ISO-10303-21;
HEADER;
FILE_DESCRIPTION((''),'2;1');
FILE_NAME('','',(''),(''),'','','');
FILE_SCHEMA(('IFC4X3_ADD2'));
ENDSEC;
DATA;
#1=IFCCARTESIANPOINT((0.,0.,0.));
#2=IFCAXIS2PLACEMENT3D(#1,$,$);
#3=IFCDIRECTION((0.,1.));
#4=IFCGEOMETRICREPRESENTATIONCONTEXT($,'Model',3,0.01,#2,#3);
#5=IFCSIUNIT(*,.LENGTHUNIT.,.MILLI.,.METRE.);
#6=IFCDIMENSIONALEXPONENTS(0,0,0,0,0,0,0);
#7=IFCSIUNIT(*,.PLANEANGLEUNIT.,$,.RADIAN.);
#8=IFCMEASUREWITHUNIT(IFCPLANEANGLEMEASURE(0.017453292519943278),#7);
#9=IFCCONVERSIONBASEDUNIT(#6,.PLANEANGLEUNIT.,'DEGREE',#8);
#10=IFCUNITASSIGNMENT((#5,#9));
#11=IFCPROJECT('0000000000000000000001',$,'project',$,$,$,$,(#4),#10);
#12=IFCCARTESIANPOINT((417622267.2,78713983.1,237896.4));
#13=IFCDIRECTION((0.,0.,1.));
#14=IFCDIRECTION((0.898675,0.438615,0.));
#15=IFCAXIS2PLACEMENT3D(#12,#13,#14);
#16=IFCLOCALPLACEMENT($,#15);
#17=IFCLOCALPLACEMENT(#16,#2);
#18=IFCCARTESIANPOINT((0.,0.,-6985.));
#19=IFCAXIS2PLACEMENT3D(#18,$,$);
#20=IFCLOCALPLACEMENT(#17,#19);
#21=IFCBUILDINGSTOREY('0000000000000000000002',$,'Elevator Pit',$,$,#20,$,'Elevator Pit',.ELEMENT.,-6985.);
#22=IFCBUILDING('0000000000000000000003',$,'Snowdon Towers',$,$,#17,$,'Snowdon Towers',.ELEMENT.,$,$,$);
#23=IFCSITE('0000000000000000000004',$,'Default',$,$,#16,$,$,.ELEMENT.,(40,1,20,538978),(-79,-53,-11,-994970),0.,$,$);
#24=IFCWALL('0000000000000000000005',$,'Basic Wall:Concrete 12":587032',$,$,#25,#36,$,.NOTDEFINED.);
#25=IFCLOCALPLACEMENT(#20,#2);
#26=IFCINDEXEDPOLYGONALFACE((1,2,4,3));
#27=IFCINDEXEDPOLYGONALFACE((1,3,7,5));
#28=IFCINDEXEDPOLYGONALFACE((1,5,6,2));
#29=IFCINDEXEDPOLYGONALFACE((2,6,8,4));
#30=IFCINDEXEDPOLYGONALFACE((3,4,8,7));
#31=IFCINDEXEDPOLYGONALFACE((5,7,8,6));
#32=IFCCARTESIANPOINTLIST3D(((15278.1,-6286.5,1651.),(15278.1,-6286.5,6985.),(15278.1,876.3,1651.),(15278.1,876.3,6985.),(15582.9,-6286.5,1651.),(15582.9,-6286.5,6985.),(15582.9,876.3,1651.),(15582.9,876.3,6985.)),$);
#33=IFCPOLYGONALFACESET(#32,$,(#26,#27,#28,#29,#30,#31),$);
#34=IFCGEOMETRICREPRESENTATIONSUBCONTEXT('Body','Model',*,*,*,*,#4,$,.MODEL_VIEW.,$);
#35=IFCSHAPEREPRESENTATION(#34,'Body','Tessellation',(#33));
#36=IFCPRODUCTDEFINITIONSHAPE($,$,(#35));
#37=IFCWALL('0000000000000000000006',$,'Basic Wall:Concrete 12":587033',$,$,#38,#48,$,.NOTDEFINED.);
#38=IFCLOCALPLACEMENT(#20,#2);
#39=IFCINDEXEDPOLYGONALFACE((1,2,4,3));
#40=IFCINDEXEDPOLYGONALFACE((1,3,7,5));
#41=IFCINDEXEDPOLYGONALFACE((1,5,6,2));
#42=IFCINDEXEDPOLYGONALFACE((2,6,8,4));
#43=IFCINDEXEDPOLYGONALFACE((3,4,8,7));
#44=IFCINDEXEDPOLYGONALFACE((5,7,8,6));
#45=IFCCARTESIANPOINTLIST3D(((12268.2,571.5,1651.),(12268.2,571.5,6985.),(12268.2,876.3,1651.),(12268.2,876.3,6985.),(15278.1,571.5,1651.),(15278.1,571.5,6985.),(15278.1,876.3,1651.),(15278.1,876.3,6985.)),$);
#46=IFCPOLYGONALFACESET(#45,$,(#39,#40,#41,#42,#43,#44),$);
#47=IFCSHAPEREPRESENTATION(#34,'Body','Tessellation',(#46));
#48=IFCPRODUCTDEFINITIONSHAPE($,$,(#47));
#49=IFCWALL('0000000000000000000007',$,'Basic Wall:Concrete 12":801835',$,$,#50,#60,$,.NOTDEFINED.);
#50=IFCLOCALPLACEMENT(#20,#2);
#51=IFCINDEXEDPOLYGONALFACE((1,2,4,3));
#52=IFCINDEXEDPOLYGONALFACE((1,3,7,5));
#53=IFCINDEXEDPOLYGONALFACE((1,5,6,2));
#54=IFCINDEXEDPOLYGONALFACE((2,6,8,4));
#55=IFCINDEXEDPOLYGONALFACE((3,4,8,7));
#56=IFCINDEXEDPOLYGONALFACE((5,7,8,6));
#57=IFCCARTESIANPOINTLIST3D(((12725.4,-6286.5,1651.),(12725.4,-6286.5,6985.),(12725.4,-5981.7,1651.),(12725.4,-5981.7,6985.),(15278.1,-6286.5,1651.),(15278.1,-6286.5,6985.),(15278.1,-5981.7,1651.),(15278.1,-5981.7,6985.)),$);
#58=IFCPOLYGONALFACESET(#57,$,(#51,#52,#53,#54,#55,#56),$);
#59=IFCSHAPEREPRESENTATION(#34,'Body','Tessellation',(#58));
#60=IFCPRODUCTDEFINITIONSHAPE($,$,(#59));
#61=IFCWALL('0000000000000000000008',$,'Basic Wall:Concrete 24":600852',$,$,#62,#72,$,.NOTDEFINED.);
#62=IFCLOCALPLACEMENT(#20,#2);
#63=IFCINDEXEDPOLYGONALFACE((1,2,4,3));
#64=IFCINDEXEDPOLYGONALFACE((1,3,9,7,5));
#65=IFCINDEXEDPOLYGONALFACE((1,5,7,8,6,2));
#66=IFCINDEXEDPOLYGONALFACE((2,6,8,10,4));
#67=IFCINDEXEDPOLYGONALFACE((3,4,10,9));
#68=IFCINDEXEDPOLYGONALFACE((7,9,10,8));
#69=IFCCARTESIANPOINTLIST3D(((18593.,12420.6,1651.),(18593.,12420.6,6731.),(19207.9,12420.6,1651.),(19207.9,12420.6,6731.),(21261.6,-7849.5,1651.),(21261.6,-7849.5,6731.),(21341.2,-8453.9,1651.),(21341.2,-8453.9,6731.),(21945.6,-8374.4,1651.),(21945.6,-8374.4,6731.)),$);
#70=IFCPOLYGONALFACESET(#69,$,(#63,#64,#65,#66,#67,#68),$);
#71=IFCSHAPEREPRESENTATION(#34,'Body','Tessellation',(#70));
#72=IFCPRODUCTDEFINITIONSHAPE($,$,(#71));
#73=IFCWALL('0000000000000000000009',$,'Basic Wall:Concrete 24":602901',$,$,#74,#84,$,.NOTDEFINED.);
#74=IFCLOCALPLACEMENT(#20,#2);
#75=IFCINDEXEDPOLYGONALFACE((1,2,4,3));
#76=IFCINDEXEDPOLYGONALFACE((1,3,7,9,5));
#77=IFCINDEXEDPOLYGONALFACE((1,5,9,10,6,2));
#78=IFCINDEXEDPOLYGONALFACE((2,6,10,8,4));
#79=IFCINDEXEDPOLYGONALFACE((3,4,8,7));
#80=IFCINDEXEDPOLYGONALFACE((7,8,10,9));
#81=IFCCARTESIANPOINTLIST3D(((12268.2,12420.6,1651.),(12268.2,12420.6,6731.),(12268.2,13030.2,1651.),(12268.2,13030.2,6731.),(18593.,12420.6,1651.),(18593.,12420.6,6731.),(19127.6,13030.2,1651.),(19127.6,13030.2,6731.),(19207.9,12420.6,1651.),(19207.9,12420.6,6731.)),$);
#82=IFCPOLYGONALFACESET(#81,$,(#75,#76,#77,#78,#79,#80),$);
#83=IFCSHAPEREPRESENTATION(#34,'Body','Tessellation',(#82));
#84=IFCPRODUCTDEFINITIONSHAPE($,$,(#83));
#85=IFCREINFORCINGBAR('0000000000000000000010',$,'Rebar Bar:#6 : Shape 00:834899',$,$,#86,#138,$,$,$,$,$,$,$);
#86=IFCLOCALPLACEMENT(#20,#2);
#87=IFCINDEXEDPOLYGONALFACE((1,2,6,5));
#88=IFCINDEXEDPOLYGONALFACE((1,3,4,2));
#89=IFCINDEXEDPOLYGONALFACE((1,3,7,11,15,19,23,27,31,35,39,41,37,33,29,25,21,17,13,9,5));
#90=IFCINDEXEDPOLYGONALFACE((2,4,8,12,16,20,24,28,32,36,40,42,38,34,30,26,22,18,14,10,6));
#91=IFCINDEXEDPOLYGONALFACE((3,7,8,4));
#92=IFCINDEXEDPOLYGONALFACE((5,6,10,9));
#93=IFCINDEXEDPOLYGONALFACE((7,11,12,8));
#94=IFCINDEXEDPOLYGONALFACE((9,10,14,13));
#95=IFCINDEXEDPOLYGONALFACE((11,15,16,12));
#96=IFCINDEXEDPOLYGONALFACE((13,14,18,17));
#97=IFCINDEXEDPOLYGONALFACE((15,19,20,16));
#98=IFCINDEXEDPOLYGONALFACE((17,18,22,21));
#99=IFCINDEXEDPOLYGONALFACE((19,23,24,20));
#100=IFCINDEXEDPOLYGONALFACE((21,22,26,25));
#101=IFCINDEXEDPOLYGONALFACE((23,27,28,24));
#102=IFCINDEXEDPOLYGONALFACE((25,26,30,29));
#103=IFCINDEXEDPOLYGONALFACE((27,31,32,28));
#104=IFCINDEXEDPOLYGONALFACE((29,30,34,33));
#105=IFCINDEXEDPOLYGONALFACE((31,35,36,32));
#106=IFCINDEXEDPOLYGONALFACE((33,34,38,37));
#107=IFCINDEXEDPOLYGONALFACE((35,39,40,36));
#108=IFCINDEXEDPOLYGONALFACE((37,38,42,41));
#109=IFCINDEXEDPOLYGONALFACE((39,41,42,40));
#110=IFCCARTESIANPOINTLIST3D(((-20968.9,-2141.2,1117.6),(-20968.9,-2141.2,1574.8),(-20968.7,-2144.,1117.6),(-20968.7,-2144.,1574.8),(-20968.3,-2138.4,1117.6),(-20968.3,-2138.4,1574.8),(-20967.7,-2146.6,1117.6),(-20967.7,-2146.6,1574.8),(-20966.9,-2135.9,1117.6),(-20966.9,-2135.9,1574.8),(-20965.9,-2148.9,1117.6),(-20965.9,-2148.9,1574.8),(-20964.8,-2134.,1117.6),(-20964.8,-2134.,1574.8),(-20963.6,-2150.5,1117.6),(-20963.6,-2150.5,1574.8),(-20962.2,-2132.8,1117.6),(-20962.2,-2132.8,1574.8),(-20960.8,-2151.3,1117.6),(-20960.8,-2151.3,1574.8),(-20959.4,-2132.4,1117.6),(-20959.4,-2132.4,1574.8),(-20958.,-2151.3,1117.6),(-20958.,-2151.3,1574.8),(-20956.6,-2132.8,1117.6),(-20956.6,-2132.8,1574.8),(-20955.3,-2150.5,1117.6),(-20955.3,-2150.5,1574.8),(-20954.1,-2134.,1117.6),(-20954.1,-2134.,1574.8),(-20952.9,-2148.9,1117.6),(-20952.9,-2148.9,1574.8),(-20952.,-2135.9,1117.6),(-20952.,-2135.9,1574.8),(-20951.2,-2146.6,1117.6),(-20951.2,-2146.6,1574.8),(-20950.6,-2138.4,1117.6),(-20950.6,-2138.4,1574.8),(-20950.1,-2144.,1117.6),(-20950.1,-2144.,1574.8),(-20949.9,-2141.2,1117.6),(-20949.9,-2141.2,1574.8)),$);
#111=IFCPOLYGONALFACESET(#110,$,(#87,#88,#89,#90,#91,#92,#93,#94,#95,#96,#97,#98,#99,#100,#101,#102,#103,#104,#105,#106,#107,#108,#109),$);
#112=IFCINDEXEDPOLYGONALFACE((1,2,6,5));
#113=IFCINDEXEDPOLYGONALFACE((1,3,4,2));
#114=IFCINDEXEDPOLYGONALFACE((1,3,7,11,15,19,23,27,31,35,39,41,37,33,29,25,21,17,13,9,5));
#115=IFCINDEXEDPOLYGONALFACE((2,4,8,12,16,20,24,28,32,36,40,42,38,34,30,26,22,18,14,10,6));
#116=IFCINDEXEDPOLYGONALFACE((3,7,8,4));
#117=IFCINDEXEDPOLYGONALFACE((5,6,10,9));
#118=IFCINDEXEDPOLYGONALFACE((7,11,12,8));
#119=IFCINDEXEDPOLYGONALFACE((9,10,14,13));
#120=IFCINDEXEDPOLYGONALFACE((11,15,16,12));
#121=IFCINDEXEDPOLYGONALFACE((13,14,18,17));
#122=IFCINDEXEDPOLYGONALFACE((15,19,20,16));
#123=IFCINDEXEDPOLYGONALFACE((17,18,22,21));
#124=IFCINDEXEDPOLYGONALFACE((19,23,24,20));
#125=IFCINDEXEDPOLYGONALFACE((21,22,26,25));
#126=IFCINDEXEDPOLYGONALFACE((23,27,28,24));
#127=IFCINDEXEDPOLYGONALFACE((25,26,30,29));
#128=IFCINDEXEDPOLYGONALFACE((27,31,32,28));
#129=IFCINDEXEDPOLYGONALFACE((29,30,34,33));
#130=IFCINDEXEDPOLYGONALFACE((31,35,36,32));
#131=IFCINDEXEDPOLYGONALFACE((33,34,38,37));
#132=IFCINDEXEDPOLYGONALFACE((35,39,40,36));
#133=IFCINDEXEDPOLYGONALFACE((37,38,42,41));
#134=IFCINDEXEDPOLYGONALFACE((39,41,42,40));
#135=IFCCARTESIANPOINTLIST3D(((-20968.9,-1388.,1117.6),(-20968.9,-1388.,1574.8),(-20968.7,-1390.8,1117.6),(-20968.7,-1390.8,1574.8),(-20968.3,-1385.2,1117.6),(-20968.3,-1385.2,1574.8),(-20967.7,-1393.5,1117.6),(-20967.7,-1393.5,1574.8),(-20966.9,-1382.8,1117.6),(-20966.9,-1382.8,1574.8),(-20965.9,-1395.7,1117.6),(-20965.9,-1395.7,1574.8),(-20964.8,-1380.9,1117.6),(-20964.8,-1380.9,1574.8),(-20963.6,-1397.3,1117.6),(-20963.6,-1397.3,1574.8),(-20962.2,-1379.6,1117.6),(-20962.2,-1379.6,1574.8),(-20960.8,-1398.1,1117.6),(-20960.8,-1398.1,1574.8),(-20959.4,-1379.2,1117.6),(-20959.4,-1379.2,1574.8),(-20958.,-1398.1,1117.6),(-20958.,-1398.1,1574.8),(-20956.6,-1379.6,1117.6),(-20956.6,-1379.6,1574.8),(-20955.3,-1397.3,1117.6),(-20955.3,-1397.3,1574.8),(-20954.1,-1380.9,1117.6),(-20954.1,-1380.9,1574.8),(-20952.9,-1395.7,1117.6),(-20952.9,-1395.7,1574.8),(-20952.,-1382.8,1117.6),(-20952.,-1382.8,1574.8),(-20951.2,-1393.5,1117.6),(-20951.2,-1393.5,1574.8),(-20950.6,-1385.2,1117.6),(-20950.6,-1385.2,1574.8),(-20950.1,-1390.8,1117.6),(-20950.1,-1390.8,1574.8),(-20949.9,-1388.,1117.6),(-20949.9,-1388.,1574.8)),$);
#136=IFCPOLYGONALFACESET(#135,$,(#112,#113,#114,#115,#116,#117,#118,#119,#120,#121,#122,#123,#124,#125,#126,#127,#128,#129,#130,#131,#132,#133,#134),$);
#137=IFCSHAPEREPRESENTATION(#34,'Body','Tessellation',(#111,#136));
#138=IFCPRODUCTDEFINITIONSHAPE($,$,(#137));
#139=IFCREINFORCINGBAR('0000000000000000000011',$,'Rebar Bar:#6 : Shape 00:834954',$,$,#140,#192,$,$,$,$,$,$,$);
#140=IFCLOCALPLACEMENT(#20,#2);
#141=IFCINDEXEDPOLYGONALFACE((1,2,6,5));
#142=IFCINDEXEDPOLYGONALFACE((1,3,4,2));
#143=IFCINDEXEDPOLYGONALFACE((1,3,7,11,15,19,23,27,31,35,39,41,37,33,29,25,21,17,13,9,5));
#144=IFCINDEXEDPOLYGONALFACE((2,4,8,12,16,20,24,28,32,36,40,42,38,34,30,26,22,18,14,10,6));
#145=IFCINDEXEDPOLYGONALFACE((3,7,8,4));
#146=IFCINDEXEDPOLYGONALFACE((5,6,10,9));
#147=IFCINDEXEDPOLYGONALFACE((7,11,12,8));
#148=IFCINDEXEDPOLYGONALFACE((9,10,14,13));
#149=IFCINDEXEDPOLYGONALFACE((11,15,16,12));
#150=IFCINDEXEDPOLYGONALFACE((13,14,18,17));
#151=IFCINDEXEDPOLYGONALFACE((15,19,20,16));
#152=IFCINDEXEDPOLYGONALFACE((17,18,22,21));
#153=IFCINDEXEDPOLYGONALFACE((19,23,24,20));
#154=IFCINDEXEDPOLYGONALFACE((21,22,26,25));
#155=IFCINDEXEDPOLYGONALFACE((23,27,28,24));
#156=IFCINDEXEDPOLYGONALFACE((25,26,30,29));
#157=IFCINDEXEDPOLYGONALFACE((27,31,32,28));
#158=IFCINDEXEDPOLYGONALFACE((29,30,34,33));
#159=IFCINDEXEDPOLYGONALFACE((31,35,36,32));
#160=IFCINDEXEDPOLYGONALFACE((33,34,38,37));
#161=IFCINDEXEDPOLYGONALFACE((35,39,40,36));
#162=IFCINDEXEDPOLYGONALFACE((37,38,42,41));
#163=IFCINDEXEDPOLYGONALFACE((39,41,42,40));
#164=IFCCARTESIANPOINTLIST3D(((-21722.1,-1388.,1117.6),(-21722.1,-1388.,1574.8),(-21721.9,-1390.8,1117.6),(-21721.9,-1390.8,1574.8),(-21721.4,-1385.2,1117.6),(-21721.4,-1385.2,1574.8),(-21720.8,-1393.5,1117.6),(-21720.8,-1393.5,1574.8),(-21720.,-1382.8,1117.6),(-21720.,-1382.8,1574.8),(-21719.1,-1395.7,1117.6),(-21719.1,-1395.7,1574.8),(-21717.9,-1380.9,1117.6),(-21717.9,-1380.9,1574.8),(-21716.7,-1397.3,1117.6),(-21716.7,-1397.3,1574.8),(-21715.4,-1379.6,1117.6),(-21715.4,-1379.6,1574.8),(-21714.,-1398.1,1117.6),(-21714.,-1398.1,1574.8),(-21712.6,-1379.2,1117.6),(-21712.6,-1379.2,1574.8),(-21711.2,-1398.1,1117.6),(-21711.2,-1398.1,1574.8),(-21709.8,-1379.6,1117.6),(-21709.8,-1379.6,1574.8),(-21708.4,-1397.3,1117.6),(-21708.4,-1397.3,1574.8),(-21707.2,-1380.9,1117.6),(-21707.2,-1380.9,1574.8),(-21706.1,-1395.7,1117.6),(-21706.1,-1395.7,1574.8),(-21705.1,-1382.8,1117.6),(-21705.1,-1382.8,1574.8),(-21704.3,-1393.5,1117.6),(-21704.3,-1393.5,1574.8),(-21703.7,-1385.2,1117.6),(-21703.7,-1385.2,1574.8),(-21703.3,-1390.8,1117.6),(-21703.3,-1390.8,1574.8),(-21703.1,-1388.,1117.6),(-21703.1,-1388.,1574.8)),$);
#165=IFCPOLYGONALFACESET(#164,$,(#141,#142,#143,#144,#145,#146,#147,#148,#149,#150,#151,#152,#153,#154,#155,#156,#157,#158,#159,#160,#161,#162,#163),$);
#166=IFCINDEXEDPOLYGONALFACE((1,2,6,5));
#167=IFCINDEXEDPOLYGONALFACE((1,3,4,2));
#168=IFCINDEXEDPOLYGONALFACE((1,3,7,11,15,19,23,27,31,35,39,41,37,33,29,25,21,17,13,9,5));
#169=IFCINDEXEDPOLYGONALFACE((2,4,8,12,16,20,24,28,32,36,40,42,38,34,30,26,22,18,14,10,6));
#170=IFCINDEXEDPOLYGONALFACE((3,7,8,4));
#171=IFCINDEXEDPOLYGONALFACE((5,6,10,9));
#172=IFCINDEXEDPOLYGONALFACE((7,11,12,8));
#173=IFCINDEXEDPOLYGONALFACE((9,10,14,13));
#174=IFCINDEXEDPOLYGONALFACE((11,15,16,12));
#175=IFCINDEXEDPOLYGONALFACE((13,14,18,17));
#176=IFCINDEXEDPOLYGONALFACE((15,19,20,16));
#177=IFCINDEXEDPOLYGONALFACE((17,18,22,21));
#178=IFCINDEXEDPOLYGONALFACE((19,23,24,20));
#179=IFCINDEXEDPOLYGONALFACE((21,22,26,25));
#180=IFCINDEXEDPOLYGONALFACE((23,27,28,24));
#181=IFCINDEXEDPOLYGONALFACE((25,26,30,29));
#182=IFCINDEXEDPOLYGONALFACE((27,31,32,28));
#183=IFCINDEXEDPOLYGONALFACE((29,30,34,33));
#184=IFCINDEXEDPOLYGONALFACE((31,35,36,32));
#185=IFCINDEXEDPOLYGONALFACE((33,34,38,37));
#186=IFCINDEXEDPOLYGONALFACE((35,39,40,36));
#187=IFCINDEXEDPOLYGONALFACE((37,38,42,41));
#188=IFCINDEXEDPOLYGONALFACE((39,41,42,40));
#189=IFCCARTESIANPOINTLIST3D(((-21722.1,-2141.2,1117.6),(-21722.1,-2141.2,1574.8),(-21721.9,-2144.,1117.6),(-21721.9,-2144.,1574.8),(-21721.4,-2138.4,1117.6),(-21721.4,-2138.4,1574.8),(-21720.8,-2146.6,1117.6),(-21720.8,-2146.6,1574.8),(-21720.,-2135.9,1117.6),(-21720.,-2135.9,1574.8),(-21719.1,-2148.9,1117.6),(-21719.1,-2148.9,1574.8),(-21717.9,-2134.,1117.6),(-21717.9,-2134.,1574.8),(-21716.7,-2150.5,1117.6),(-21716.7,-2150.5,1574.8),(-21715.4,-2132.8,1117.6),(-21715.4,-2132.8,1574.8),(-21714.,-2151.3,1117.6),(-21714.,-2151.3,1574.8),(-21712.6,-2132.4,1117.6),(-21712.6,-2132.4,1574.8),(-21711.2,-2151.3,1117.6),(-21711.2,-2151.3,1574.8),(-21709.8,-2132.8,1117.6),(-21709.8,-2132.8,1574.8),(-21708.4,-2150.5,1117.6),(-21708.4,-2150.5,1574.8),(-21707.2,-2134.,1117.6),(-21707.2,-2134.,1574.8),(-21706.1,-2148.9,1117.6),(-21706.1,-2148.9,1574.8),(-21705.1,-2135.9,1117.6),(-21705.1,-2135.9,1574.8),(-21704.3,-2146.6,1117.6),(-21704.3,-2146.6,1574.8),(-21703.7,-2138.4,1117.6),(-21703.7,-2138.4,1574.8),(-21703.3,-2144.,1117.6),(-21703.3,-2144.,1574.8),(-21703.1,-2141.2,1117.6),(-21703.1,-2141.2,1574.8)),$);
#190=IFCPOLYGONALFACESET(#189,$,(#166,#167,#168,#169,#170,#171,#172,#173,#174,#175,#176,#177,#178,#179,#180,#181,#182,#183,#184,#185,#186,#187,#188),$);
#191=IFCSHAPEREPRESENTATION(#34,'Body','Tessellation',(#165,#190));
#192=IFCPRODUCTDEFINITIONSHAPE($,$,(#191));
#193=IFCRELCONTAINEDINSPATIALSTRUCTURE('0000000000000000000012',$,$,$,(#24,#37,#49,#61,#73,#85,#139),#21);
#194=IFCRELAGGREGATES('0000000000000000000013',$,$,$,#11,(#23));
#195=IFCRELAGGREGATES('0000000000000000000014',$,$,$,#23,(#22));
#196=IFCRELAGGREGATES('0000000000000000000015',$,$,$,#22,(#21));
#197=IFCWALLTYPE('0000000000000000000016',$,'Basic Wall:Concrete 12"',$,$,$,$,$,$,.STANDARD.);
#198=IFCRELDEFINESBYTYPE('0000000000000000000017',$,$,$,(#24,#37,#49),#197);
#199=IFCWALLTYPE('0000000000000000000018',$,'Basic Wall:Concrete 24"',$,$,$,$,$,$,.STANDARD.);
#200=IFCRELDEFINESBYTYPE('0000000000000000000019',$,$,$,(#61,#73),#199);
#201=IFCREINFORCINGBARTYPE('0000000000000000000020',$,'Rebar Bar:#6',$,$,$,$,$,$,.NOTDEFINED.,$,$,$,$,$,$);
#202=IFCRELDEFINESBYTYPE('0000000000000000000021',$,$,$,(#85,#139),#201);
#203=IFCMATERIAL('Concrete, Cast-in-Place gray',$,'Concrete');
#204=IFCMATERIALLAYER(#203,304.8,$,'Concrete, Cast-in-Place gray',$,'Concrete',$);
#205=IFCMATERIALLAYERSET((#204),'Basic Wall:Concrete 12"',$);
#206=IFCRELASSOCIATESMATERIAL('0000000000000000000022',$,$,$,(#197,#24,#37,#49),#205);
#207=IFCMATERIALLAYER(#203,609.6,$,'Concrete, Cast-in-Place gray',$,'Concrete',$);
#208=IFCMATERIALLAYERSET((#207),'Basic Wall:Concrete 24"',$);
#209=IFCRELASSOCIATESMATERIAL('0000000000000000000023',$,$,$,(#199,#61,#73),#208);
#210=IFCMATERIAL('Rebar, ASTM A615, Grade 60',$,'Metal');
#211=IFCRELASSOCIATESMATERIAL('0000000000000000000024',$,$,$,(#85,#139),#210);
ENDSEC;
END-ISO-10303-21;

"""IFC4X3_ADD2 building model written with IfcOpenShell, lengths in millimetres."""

from ifc_helpers import new_model, entity, si_unit, converted_unit, direction, frame, frame_2d, origin, place, context, subcontext, project, spatial, polyline, rectangle, outline, extrude, material, layer, layer_set, type_object, element, save


model = new_model("IFC4X3_ADD2")

# Units and contexts
model_context = context("Model", 3, precision=0.01, world=origin(), true_north=direction((0.0, 1.0)))
body_context = subcontext(model_context, "Body", "Model", "MODEL_VIEW")
ifc_project = project(units=[si_unit("LENGTHUNIT", "METRE", prefix="MILLI"), converted_unit("PLANEANGLEUNIT", "DEGREE", entity("IfcPlaneAngleMeasure", 0.017453292519943278), si_unit("PLANEANGLEUNIT", "RADIAN"), dimensions=[0, 0, 0, 0, 0, 0, 0])], contexts=[model_context])

# Site, building, storey
site_placement = place(None, frame((417622267.2, 78713983.1, 237896.4), z_axis=(0.0, 0.0, 1.0), x_axis=(0.898675, 0.438615, 0.0)))
site = spatial("IfcSite", under=ifc_project, at=site_placement, Name="Default", CompositionType="ELEMENT", RefLatitude=(40, 1, 20, 538978), RefLongitude=(-79, -53, -11, -994970), RefElevation=0.0)
building_placement = place(site_placement, origin())
building = spatial("IfcBuilding", under=site, at=building_placement, Name="Snowdon Towers", LongName="Snowdon Towers", CompositionType="ELEMENT")
storey_placement = place(building_placement, frame((0.0, 0.0, -6985.0)))
storey = spatial("IfcBuildingStorey", under=building, at=storey_placement, Name="Elevator Pit", LongName="Elevator Pit", CompositionType="ELEMENT", Elevation=-6985.0)

# Shared definitions
ifc_material_1 = material(Name="Concrete, Cast-in-Place gray", Category="Concrete")

# Walls
ifc_layer_1 = layer(ifc_material_1, 304.8, Name="Concrete, Cast-in-Place gray", Category="Concrete")
ifc_layer_set_1 = layer_set([ifc_layer_1], Name="Basic Wall:Concrete 12\"")
wall_type_1 = type_object("IfcWallType", Name="Basic Wall:Concrete 12\"", PredefinedType="STANDARD", material=ifc_layer_set_1)
wall_1_placement = place(storey_placement, frame((15430.5, -6286.5, 1651.0), z_axis=(0.0, 0.0, 1.0), x_axis=(0.0, 1.0, 0.0)))
element("IfcWall", 1, at=wall_1_placement, inside=storey, type_object=wall_type_1, material=ifc_layer_set_1, Name="Basic Wall:Concrete 12\":587032", PredefinedType="NOTDEFINED", context=body_context, shape_type="SweptSolid", body=[
    extrude(rectangle(XDim=7162.8, YDim=304.8, at=frame_2d((3581.4, 0.0), x_axis=(-1.0, 0.0))), origin(), (0.0, 0.0, 1.0), 5334.0),
])
wall_2_placement = place(storey_placement, frame((15278.1, 723.9, 1651.0), z_axis=(0.0, 0.0, 1.0), x_axis=(-1.0, 0.0, 0.0)))
element("IfcWall", 2, at=wall_2_placement, inside=storey, type_object=wall_type_1, material=ifc_layer_set_1, Name="Basic Wall:Concrete 12\":587033", PredefinedType="NOTDEFINED", context=body_context, shape_type="SweptSolid", body=[
    extrude(rectangle(XDim=3009.9, YDim=304.8, at=frame_2d((1504.9, 0.0), x_axis=(-1.0, 0.0))), origin(), (0.0, 0.0, 1.0), 5334.0),
])
wall_3_placement = place(storey_placement, frame((15278.1, -6134.1, 1651.0), z_axis=(0.0, 0.0, 1.0), x_axis=(-1.0, 0.0, 0.0)))
element("IfcWall", 3, at=wall_3_placement, inside=storey, type_object=wall_type_1, material=ifc_layer_set_1, Name="Basic Wall:Concrete 12\":801835", PredefinedType="NOTDEFINED", context=body_context, shape_type="SweptSolid", body=[
    extrude(rectangle(XDim=2552.7, YDim=304.8, at=frame_2d((1276.3, 0.0), x_axis=(-1.0, 0.0))), origin(), (0.0, 0.0, 1.0), 5334.0),
])
ifc_layer_2 = layer(ifc_material_1, 609.6, Name="Concrete, Cast-in-Place gray", Category="Concrete")
ifc_layer_set_2 = layer_set([ifc_layer_2], Name="Basic Wall:Concrete 24\"")
wall_type_2 = type_object("IfcWallType", Name="Basic Wall:Concrete 24\"", PredefinedType="STANDARD", material=ifc_layer_set_2)
wall_4_placement = place(storey_placement, frame((18895.2, 12460.4, 1651.0), z_axis=(0.0, 0.0, 1.0), x_axis=(0.130526, -0.991445, 0.0)))
element("IfcWall", 4, at=wall_4_placement, inside=storey, type_object=wall_type_2, material=ifc_layer_set_2, Name="Basic Wall:Concrete 24\":600852", PredefinedType="NOTDEFINED", context=body_context, shape_type="SweptSolid", body=[
    extrude(outline(polyline([(21054.6, -304.8), (21054.6, 304.8), (80.3, 304.8), (0.0, -304.8), (20445.0, -304.8), (21054.6, -304.8)])), origin(), (0.0, 0.0, 1.0), 5080.0),
])
wall_5_placement = place(storey_placement, frame((12268.2, 12725.4, 1651.0)))
element("IfcWall", 5, at=wall_5_placement, inside=storey, type_object=wall_type_2, material=ifc_layer_set_2, Name="Basic Wall:Concrete 24\":602901", PredefinedType="NOTDEFINED", context=body_context, shape_type="SweptSolid", body=[
    extrude(outline(polyline([(6939.7, -304.8), (6859.4, 304.8), (0.0, 304.8), (0.0, -304.8), (6324.8, -304.8), (6939.7, -304.8)])), origin(), (0.0, 0.0, 1.0), 5080.0),
])

# Reinforcing bars
ifc_material_2 = material(Name="Rebar, ASTM A615, Grade 60", Category="Metal")
reinforcing_bar_type_1 = type_object("IfcReinforcingBarType", Name="Rebar Bar:#6", PredefinedType="NOTDEFINED")
reinforcing_bar_1_placement = place(storey_placement, origin())
element("IfcReinforcingBar", 6, at=reinforcing_bar_1_placement, inside=storey, type_object=reinforcing_bar_type_1, material=ifc_material_2, Name="Rebar Bar:#6 : Shape 00:834899", context=body_context, shape_type="AdvancedSweptSolid", body=[
    entity("IfcSweptDiskSolid", entity("IfcCompositeCurve", [entity("IfcCompositeCurveSegment", "CONTINUOUS", True, entity("IfcPolyline", [entity("IfcCartesianPoint", [-20959.4, -2141.9, 1117.6]), entity("IfcCartesianPoint", [-20959.4, -2141.9, 1574.8])]))], False), 9.5, None, 0.0, 1.0),
    entity("IfcSweptDiskSolid", entity("IfcCompositeCurve", [entity("IfcCompositeCurveSegment", "CONTINUOUS", True, entity("IfcPolyline", [entity("IfcCartesianPoint", [-20959.4, -1388.7, 1117.6]), entity("IfcCartesianPoint", [-20959.4, -1388.7, 1574.8])]))], False), 9.5, None, 0.0, 1.0),
])
reinforcing_bar_2_placement = place(storey_placement, origin())
element("IfcReinforcingBar", 7, at=reinforcing_bar_2_placement, inside=storey, type_object=reinforcing_bar_type_1, material=ifc_material_2, Name="Rebar Bar:#6 : Shape 00:834954", context=body_context, shape_type="AdvancedSweptSolid", body=[
    entity("IfcSweptDiskSolid", entity("IfcCompositeCurve", [entity("IfcCompositeCurveSegment", "CONTINUOUS", True, entity("IfcPolyline", [entity("IfcCartesianPoint", [-21712.6, -1388.7, 1117.6]), entity("IfcCartesianPoint", [-21712.6, -1388.7, 1574.8])]))], False), 9.5, None, 0.0, 1.0),
    entity("IfcSweptDiskSolid", entity("IfcCompositeCurve", [entity("IfcCompositeCurveSegment", "CONTINUOUS", True, entity("IfcPolyline", [entity("IfcCartesianPoint", [-21712.6, -2141.9, 1117.6]), entity("IfcCartesianPoint", [-21712.6, -2141.9, 1574.8])]))], False), 9.5, None, 0.0, 1.0),
])

save(model, "model.ifc")
